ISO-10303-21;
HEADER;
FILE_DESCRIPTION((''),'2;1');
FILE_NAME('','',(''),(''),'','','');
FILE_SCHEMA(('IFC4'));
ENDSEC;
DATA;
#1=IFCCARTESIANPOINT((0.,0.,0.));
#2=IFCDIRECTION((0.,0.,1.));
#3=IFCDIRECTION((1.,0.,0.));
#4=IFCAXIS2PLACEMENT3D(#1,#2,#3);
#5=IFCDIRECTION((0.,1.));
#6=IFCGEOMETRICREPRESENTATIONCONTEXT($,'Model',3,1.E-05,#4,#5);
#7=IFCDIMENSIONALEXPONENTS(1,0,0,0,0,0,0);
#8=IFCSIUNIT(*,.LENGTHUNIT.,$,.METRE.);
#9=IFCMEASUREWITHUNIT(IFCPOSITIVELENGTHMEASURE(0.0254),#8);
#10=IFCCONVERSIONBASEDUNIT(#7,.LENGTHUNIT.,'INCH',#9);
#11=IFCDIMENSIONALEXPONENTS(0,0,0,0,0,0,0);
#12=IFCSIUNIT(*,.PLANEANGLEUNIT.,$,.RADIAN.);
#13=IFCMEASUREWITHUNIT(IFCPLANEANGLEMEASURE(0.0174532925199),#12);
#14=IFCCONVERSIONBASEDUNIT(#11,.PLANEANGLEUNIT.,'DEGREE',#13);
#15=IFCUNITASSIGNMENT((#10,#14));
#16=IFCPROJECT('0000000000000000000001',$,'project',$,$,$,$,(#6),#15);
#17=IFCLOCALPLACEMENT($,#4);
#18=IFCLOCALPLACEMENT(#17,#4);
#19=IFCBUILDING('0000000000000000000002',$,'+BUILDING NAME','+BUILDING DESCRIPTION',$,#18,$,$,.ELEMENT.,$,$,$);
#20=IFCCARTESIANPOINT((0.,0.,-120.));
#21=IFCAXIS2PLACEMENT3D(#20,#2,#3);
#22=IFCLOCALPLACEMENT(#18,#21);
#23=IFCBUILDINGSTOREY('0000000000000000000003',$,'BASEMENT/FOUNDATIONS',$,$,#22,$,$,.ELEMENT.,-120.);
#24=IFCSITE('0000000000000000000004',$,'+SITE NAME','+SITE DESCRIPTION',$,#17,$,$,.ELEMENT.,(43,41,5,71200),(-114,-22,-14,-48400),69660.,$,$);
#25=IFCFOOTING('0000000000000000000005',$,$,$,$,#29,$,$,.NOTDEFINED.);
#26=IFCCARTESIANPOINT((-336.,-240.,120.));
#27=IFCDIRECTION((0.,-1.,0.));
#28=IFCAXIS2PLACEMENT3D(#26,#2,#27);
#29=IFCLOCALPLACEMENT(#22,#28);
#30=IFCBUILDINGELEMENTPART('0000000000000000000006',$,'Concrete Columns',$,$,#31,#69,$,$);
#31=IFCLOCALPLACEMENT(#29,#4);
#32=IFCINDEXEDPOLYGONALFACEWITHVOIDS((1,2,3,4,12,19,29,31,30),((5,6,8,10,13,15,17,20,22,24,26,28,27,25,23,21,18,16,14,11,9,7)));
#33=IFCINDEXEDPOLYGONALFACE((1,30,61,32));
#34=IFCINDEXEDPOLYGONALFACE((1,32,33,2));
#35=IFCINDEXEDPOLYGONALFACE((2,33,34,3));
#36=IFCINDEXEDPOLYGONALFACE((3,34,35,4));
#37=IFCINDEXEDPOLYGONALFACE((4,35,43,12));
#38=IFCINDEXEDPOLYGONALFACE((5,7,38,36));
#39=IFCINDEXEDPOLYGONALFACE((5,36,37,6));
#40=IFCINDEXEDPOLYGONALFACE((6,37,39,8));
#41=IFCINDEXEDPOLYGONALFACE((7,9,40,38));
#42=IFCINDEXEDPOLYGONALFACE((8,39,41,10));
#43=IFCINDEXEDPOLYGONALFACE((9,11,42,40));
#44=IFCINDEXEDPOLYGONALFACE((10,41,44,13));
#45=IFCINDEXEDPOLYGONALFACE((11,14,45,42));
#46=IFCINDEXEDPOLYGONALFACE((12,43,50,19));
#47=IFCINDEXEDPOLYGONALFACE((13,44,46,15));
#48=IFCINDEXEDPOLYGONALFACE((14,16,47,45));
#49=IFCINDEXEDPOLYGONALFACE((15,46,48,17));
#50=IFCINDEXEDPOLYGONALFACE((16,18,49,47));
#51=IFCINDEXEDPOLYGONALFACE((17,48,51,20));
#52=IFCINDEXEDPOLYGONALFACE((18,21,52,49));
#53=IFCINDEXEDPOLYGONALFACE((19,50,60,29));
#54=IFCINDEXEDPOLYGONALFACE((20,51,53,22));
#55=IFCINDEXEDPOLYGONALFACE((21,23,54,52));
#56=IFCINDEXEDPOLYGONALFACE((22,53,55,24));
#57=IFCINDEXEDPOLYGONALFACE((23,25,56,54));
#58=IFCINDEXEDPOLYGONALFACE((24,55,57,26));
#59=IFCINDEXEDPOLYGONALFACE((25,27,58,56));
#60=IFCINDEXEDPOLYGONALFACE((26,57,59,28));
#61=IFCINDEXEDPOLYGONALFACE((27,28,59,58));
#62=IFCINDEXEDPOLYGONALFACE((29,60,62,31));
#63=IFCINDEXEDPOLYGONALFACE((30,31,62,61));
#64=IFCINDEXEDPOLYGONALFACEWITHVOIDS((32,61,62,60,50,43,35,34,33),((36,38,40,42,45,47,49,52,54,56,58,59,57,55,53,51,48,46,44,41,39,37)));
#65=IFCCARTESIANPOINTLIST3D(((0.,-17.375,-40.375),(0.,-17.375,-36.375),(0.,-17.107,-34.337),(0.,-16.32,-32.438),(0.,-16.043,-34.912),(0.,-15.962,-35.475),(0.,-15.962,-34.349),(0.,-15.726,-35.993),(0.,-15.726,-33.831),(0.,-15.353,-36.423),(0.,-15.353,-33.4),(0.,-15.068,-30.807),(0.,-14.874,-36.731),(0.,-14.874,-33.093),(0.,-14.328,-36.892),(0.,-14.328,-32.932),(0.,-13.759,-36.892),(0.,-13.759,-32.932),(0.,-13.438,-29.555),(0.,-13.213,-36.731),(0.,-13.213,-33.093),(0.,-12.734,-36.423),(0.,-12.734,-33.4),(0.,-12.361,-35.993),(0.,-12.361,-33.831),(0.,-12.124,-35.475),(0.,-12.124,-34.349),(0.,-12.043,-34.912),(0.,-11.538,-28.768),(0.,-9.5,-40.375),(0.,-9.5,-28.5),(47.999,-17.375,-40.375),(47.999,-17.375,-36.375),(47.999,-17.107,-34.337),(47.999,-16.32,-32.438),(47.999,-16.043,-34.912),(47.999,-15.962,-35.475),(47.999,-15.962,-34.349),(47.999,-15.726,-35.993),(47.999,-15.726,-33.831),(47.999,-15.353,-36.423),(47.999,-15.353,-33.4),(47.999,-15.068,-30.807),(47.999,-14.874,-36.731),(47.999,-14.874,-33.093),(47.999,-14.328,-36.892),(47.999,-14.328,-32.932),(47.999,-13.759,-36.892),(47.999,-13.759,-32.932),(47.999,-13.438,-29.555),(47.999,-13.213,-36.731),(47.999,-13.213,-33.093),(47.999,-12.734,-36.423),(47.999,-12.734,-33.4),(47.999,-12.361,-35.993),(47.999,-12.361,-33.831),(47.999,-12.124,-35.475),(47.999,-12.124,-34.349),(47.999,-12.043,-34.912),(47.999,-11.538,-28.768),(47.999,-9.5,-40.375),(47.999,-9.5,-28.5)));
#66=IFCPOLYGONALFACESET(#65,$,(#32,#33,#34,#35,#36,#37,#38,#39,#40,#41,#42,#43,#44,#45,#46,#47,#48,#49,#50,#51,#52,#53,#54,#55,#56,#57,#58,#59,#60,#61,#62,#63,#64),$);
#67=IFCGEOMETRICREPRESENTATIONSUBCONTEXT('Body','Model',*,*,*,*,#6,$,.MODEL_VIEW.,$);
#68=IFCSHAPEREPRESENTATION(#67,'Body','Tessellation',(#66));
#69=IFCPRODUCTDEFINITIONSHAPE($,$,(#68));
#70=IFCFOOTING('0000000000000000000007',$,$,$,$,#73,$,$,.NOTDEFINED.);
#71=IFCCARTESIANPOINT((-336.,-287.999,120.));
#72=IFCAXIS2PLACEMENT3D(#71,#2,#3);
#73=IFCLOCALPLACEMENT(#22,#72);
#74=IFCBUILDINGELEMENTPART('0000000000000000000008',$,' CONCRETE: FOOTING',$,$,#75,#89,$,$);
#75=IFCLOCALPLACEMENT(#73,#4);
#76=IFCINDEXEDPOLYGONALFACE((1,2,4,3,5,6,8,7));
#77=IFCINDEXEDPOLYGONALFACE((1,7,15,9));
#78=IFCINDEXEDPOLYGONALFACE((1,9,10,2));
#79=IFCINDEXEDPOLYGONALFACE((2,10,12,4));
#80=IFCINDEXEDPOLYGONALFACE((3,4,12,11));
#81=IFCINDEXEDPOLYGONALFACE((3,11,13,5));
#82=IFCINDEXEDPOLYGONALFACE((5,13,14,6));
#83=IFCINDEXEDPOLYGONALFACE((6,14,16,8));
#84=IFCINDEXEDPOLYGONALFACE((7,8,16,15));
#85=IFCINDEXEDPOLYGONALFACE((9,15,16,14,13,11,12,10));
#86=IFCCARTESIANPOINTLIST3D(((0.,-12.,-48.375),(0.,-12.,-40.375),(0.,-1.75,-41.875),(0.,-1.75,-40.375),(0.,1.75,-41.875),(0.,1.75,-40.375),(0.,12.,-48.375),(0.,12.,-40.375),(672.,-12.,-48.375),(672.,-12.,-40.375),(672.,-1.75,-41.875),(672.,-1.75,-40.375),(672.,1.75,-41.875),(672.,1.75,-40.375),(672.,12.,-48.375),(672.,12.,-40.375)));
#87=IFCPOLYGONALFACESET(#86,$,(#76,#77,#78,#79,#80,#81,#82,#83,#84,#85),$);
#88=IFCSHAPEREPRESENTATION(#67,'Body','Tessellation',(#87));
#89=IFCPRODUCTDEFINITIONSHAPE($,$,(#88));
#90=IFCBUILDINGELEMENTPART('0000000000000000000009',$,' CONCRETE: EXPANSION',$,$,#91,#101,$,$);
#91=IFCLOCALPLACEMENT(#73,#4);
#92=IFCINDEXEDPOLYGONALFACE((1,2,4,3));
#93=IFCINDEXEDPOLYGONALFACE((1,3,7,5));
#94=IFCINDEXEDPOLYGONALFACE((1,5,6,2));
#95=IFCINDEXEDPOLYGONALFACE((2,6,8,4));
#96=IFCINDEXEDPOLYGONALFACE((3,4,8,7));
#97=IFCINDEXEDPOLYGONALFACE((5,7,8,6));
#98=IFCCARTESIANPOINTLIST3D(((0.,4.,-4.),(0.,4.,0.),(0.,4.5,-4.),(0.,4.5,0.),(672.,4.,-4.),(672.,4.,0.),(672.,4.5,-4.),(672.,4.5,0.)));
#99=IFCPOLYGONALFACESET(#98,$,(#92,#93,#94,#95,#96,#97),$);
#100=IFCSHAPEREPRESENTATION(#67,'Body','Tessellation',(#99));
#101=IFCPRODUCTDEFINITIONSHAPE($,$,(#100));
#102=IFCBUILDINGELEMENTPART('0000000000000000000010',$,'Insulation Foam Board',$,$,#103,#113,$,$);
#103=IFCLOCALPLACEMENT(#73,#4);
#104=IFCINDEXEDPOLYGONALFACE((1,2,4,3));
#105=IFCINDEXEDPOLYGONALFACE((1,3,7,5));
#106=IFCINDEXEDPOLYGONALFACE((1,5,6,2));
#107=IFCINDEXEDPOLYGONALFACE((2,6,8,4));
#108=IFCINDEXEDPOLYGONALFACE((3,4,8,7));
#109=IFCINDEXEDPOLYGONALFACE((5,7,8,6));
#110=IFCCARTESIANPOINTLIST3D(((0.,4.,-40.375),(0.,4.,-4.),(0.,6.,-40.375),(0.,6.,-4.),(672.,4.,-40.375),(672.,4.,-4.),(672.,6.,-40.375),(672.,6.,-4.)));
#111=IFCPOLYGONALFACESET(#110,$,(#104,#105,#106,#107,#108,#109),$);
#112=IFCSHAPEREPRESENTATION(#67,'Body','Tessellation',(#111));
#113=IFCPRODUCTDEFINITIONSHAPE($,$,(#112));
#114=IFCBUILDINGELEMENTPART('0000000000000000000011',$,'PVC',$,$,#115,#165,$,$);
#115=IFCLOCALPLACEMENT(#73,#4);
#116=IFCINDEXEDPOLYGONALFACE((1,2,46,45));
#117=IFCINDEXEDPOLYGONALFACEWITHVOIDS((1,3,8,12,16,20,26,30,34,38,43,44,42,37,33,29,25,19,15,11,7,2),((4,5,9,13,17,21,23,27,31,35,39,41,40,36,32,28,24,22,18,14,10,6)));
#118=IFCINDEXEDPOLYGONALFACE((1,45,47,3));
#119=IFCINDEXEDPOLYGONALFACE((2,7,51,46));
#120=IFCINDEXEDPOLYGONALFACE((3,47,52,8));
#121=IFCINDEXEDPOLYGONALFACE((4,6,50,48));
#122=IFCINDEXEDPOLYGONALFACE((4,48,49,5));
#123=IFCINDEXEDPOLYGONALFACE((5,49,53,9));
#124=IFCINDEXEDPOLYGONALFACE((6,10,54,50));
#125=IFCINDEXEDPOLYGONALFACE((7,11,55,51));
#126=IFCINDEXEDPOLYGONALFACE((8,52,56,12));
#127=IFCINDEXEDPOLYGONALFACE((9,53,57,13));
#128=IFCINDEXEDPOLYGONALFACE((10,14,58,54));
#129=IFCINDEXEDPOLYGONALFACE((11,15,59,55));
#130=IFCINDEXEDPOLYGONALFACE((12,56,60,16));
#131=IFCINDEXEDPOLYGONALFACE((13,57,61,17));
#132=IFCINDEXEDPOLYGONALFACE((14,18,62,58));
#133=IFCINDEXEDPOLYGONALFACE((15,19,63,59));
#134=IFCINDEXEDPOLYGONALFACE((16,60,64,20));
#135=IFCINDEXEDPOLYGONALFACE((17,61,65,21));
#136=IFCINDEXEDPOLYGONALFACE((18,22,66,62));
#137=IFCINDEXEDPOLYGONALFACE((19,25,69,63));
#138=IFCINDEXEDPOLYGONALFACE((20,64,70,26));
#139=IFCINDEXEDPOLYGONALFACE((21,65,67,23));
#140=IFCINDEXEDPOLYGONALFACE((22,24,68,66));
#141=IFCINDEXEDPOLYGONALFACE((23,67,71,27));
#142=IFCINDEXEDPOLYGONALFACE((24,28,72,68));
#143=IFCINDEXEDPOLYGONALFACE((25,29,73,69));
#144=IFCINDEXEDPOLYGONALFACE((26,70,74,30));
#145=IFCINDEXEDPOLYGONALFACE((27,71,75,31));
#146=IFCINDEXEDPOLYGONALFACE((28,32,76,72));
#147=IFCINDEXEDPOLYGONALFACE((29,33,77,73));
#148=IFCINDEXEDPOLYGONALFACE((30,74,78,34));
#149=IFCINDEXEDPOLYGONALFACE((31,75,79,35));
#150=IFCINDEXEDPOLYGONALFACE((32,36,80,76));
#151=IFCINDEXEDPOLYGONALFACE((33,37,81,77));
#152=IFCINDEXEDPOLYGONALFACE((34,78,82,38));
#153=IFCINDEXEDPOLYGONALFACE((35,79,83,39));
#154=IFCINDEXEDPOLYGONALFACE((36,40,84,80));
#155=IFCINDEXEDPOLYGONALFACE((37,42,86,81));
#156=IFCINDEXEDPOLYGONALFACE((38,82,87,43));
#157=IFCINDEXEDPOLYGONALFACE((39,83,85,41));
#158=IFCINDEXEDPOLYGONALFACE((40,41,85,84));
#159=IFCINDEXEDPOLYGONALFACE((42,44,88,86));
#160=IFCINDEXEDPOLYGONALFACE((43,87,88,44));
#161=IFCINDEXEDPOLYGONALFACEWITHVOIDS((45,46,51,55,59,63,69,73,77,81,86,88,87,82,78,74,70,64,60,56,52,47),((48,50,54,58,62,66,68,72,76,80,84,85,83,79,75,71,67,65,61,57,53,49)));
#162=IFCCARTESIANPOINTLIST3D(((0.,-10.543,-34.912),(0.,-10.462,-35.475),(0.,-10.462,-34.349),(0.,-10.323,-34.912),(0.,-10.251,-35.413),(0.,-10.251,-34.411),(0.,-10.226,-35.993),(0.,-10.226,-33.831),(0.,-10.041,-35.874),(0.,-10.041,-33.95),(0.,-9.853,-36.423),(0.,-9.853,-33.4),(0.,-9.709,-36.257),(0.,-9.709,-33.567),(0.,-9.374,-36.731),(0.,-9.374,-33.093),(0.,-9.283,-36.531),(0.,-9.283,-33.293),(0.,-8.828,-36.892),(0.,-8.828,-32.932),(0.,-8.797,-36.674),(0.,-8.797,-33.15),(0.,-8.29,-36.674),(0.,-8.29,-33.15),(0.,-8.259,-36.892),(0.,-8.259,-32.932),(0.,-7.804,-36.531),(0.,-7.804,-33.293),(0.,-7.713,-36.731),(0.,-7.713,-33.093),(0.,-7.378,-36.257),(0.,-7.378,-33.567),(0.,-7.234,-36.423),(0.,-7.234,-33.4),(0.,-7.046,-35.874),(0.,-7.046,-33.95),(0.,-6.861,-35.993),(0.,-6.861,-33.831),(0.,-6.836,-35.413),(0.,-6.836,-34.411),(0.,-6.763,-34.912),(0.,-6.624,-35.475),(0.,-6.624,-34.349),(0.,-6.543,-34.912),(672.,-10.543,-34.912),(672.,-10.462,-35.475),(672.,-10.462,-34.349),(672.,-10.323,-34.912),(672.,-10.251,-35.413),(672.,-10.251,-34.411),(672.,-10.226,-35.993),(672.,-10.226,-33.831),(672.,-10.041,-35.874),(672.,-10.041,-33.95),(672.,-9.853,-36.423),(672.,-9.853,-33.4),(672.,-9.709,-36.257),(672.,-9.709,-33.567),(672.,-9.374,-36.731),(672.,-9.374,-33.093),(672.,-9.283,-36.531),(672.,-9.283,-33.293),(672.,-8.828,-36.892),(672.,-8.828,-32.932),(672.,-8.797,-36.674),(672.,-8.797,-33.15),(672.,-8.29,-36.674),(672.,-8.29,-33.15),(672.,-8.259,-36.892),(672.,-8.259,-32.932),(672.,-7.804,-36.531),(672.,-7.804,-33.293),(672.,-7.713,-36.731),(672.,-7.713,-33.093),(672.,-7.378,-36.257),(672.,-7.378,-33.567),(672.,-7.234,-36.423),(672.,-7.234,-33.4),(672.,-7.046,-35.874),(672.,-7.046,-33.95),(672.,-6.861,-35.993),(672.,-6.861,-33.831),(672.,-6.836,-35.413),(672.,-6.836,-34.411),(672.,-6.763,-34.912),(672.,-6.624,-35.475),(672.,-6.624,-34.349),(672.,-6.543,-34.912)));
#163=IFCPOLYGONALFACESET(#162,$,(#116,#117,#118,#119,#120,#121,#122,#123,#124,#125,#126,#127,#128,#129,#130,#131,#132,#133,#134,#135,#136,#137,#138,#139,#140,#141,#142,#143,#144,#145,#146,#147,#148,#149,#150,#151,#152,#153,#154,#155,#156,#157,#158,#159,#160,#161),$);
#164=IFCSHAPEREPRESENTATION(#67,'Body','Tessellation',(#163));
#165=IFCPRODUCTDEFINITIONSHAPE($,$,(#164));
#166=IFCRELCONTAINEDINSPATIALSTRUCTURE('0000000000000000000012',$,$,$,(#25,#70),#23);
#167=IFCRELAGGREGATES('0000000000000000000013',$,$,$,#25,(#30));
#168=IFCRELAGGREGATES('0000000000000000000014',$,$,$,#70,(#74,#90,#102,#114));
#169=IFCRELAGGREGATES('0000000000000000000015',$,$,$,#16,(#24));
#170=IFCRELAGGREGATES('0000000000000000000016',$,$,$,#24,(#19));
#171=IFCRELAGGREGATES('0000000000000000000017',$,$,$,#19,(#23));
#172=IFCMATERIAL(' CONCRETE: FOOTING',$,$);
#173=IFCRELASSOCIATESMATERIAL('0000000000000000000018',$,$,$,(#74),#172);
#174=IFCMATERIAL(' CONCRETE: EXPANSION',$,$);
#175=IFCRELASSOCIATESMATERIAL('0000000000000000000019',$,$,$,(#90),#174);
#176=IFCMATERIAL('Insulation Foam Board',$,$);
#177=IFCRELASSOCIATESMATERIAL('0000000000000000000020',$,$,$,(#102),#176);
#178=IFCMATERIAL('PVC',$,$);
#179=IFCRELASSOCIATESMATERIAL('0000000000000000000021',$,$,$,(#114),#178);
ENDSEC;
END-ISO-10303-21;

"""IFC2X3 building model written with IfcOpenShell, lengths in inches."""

from ifc_helpers import new_model, entity, si_unit, converted_unit, point, direction, frame, frame_2d, origin_with_axes, place, context, subcontext, project, spatial, polyline, circle_curve, parameter, trimmed, segment, composite_curve, outline, extrude, material, element, aggregate, save


model = new_model("IFC2X3")

# Units and contexts
model_context = context("Model", 3, precision=1e-05, world=origin_with_axes(), true_north=direction((0.0, 1.0)))
body_context = subcontext(model_context, "Body", "Model", "MODEL_VIEW")
ifc_project = project(units=[converted_unit("LENGTHUNIT", "INCH", entity("IfcPositiveLengthMeasure", 0.0254), si_unit("LENGTHUNIT", "METRE"), dimensions=[1, 0, 0, 0, 0, 0, 0]), converted_unit("PLANEANGLEUNIT", "DEGREE", entity("IfcPlaneAngleMeasure", 0.0174532925199), si_unit("PLANEANGLEUNIT", "RADIAN"), dimensions=[0, 0, 0, 0, 0, 0, 0])], contexts=[model_context])

# Site, building, storey
site_placement = place(None, origin_with_axes())
site = spatial("IfcSite", under=ifc_project, at=site_placement, Name="+SITE NAME", Description="+SITE DESCRIPTION", CompositionType="ELEMENT", RefLatitude=(43, 41, 5, 71200), RefLongitude=(-114, -22, -14, -48400), RefElevation=69660.0)
building_placement = place(site_placement, origin_with_axes())
building = spatial("IfcBuilding", under=site, at=building_placement, Name="+BUILDING NAME", Description="+BUILDING DESCRIPTION", CompositionType="ELEMENT")
storey_placement = place(building_placement, frame((0.0, 0.0, -120.0), z_axis=(0.0, 0.0, 1.0), x_axis=(1.0, 0.0, 0.0)))
storey = spatial("IfcBuildingStorey", under=building, at=storey_placement, Name="BASEMENT/FOUNDATIONS", CompositionType="ELEMENT", Elevation=-120.0)

# Footings, building element parts
ifc_material_1 = material(Name=" CONCRETE: FOOTING")
footing_1_placement = place(storey_placement, frame((-336.0, -240.0, 120.0), z_axis=(0.0, 0.0, 1.0), x_axis=(0.0, -1.0, 0.0)))
footing_1 = element("IfcFooting", 1, at=footing_1_placement, inside=storey, PredefinedType="NOTDEFINED")
ifc_material_2 = material(Name=" CONCRETE: EXPANSION")
ifc_material_3 = material(Name="Insulation Foam Board")
ifc_material_4 = material(Name="PVC")
building_element_part_1_placement = place(footing_1_placement, origin_with_axes())
building_element_part_1 = element("IfcBuildingElementPart", 2, at=building_element_part_1_placement, Name="Concrete Columns", context=body_context, shape_type="SweptSolid", body=[
    extrude(outline(composite_curve([segment(trimmed(circle_curve(frame_2d((9.5, -36.375), x_axis=(1.0, 0.0)), 7.875), [point((17.375, -36.375)), parameter(0.0)], [point((9.5, -28.5)), parameter(90.0)], True, "CARTESIAN"), True, "CONTINUOUS"), segment(polyline([(9.5, -28.5), (9.5, -40.375), (17.375, -40.375), (17.375, -36.375)]), True, "CONTINUOUS")], self_intersect=False), holes=[composite_curve([segment(trimmed(circle_curve(frame_2d((14.043, -34.912), x_axis=(-1.0, 0.0)), 2.0), [point((16.043, -34.912)), parameter(180.0)], [point((12.043, -34.912)), parameter(0.0)], False, "CARTESIAN"), True, "CONTINUOUS"), segment(trimmed(circle_curve(frame_2d((14.043, -34.912), x_axis=(1.0, 0.0)), 2.0), [point((12.043, -34.912)), parameter(180.0)], [point((16.043, -34.912)), parameter(0.0)], False, "CARTESIAN"), True, "CONTINUOUS")], self_intersect=False)]), frame((0.0, 0.0, 0.0), z_axis=(-1.0, 0.0, 0.0), x_axis=(0.0, -1.0, 0.0)), (0.0, 0.0, -1.0), 47.999),
])
aggregate(footing_1, [building_element_part_1])
footing_2_placement = place(storey_placement, frame((-336.0, -287.999, 120.0), z_axis=(0.0, 0.0, 1.0), x_axis=(1.0, 0.0, 0.0)))
footing_2 = element("IfcFooting", 3, at=footing_2_placement, inside=storey, PredefinedType="NOTDEFINED")
building_element_part_2_placement = place(footing_2_placement, origin_with_axes())
building_element_part_2 = element("IfcBuildingElementPart", 4, at=building_element_part_2_placement, material=ifc_material_1, Name=" CONCRETE: FOOTING", context=body_context, shape_type="SweptSolid", body=[
    extrude(outline(polyline([(-12.0, -48.375), (12.0, -48.375), (12.0, -40.375), (1.75, -40.375), (1.75, -41.875), (-1.75, -41.875), (-1.75, -40.375), (-12.0, -40.375), (-12.0, -48.375)])), frame((0.0, 0.0, 0.0), z_axis=(-1.0, 0.0, 0.0), x_axis=(0.0, -1.0, 0.0)), (0.0, 0.0, -1.0), 672.0),
])
building_element_part_3_placement = place(footing_2_placement, origin_with_axes())
building_element_part_3 = element("IfcBuildingElementPart", 5, at=building_element_part_3_placement, material=ifc_material_2, Name=" CONCRETE: EXPANSION", context=body_context, shape_type="SweptSolid", body=[
    extrude(outline(polyline([(-4.0, 0.0), (-4.5, 0.0), (-4.5, -4.0), (-4.0, -4.0), (-4.0, 0.0)])), frame((0.0, 0.0, 0.0), z_axis=(-1.0, 0.0, 0.0), x_axis=(0.0, -1.0, 0.0)), (0.0, 0.0, -1.0), 672.0),
])
building_element_part_4_placement = place(footing_2_placement, origin_with_axes())
building_element_part_4 = element("IfcBuildingElementPart", 6, at=building_element_part_4_placement, material=ifc_material_3, Name="Insulation Foam Board", context=body_context, shape_type="SweptSolid", body=[
    extrude(outline(polyline([(-4.0, -4.0), (-6.0, -4.0), (-6.0, -40.375), (-4.0, -40.375), (-4.0, -4.0)])), frame((0.0, 0.0, 0.0), z_axis=(-1.0, 0.0, 0.0), x_axis=(0.0, -1.0, 0.0)), (0.0, 0.0, -1.0), 672.0),
])
building_element_part_5_placement = place(footing_2_placement, origin_with_axes())
building_element_part_5 = element("IfcBuildingElementPart", 7, at=building_element_part_5_placement, material=ifc_material_4, Name="PVC", context=body_context, shape_type="SweptSolid", body=[
    extrude(outline(composite_curve([segment(trimmed(circle_curve(frame_2d((8.543, -34.912), x_axis=(1.0, 0.0)), 2.0), [point((10.543, -34.912)), parameter(0.0)], [point((6.543, -34.912)), parameter(180.0)], True, "CARTESIAN"), True, "CONTINUOUS"), segment(trimmed(circle_curve(frame_2d((8.543, -34.912), x_axis=(-1.0, 0.0)), 2.0), [point((6.543, -34.912)), parameter(0.0)], [point((10.543, -34.912)), parameter(180.0)], True, "CARTESIAN"), True, "CONTINUOUS")], self_intersect=False), holes=[composite_curve([segment(trimmed(circle_curve(frame_2d((8.543, -34.912), x_axis=(-1.0, 0.0)), 1.78), [point((10.323, -34.912)), parameter(180.0)], [point((6.763, -34.912)), parameter(0.0)], False, "CARTESIAN"), True, "CONTINUOUS"), segment(trimmed(circle_curve(frame_2d((8.543, -34.912), x_axis=(1.0, 0.0)), 1.78), [point((6.763, -34.912)), parameter(180.0)], [point((10.323, -34.912)), parameter(0.0)], False, "CARTESIAN"), True, "CONTINUOUS")], self_intersect=False)]), frame((0.0, 0.0, 0.0), z_axis=(-1.0, 0.0, 0.0), x_axis=(0.0, -1.0, 0.0)), (0.0, 0.0, -1.0), 672.0),
])
aggregate(footing_2, [building_element_part_2, building_element_part_3, building_element_part_4, building_element_part_5])

save(model, "model.ifc")
